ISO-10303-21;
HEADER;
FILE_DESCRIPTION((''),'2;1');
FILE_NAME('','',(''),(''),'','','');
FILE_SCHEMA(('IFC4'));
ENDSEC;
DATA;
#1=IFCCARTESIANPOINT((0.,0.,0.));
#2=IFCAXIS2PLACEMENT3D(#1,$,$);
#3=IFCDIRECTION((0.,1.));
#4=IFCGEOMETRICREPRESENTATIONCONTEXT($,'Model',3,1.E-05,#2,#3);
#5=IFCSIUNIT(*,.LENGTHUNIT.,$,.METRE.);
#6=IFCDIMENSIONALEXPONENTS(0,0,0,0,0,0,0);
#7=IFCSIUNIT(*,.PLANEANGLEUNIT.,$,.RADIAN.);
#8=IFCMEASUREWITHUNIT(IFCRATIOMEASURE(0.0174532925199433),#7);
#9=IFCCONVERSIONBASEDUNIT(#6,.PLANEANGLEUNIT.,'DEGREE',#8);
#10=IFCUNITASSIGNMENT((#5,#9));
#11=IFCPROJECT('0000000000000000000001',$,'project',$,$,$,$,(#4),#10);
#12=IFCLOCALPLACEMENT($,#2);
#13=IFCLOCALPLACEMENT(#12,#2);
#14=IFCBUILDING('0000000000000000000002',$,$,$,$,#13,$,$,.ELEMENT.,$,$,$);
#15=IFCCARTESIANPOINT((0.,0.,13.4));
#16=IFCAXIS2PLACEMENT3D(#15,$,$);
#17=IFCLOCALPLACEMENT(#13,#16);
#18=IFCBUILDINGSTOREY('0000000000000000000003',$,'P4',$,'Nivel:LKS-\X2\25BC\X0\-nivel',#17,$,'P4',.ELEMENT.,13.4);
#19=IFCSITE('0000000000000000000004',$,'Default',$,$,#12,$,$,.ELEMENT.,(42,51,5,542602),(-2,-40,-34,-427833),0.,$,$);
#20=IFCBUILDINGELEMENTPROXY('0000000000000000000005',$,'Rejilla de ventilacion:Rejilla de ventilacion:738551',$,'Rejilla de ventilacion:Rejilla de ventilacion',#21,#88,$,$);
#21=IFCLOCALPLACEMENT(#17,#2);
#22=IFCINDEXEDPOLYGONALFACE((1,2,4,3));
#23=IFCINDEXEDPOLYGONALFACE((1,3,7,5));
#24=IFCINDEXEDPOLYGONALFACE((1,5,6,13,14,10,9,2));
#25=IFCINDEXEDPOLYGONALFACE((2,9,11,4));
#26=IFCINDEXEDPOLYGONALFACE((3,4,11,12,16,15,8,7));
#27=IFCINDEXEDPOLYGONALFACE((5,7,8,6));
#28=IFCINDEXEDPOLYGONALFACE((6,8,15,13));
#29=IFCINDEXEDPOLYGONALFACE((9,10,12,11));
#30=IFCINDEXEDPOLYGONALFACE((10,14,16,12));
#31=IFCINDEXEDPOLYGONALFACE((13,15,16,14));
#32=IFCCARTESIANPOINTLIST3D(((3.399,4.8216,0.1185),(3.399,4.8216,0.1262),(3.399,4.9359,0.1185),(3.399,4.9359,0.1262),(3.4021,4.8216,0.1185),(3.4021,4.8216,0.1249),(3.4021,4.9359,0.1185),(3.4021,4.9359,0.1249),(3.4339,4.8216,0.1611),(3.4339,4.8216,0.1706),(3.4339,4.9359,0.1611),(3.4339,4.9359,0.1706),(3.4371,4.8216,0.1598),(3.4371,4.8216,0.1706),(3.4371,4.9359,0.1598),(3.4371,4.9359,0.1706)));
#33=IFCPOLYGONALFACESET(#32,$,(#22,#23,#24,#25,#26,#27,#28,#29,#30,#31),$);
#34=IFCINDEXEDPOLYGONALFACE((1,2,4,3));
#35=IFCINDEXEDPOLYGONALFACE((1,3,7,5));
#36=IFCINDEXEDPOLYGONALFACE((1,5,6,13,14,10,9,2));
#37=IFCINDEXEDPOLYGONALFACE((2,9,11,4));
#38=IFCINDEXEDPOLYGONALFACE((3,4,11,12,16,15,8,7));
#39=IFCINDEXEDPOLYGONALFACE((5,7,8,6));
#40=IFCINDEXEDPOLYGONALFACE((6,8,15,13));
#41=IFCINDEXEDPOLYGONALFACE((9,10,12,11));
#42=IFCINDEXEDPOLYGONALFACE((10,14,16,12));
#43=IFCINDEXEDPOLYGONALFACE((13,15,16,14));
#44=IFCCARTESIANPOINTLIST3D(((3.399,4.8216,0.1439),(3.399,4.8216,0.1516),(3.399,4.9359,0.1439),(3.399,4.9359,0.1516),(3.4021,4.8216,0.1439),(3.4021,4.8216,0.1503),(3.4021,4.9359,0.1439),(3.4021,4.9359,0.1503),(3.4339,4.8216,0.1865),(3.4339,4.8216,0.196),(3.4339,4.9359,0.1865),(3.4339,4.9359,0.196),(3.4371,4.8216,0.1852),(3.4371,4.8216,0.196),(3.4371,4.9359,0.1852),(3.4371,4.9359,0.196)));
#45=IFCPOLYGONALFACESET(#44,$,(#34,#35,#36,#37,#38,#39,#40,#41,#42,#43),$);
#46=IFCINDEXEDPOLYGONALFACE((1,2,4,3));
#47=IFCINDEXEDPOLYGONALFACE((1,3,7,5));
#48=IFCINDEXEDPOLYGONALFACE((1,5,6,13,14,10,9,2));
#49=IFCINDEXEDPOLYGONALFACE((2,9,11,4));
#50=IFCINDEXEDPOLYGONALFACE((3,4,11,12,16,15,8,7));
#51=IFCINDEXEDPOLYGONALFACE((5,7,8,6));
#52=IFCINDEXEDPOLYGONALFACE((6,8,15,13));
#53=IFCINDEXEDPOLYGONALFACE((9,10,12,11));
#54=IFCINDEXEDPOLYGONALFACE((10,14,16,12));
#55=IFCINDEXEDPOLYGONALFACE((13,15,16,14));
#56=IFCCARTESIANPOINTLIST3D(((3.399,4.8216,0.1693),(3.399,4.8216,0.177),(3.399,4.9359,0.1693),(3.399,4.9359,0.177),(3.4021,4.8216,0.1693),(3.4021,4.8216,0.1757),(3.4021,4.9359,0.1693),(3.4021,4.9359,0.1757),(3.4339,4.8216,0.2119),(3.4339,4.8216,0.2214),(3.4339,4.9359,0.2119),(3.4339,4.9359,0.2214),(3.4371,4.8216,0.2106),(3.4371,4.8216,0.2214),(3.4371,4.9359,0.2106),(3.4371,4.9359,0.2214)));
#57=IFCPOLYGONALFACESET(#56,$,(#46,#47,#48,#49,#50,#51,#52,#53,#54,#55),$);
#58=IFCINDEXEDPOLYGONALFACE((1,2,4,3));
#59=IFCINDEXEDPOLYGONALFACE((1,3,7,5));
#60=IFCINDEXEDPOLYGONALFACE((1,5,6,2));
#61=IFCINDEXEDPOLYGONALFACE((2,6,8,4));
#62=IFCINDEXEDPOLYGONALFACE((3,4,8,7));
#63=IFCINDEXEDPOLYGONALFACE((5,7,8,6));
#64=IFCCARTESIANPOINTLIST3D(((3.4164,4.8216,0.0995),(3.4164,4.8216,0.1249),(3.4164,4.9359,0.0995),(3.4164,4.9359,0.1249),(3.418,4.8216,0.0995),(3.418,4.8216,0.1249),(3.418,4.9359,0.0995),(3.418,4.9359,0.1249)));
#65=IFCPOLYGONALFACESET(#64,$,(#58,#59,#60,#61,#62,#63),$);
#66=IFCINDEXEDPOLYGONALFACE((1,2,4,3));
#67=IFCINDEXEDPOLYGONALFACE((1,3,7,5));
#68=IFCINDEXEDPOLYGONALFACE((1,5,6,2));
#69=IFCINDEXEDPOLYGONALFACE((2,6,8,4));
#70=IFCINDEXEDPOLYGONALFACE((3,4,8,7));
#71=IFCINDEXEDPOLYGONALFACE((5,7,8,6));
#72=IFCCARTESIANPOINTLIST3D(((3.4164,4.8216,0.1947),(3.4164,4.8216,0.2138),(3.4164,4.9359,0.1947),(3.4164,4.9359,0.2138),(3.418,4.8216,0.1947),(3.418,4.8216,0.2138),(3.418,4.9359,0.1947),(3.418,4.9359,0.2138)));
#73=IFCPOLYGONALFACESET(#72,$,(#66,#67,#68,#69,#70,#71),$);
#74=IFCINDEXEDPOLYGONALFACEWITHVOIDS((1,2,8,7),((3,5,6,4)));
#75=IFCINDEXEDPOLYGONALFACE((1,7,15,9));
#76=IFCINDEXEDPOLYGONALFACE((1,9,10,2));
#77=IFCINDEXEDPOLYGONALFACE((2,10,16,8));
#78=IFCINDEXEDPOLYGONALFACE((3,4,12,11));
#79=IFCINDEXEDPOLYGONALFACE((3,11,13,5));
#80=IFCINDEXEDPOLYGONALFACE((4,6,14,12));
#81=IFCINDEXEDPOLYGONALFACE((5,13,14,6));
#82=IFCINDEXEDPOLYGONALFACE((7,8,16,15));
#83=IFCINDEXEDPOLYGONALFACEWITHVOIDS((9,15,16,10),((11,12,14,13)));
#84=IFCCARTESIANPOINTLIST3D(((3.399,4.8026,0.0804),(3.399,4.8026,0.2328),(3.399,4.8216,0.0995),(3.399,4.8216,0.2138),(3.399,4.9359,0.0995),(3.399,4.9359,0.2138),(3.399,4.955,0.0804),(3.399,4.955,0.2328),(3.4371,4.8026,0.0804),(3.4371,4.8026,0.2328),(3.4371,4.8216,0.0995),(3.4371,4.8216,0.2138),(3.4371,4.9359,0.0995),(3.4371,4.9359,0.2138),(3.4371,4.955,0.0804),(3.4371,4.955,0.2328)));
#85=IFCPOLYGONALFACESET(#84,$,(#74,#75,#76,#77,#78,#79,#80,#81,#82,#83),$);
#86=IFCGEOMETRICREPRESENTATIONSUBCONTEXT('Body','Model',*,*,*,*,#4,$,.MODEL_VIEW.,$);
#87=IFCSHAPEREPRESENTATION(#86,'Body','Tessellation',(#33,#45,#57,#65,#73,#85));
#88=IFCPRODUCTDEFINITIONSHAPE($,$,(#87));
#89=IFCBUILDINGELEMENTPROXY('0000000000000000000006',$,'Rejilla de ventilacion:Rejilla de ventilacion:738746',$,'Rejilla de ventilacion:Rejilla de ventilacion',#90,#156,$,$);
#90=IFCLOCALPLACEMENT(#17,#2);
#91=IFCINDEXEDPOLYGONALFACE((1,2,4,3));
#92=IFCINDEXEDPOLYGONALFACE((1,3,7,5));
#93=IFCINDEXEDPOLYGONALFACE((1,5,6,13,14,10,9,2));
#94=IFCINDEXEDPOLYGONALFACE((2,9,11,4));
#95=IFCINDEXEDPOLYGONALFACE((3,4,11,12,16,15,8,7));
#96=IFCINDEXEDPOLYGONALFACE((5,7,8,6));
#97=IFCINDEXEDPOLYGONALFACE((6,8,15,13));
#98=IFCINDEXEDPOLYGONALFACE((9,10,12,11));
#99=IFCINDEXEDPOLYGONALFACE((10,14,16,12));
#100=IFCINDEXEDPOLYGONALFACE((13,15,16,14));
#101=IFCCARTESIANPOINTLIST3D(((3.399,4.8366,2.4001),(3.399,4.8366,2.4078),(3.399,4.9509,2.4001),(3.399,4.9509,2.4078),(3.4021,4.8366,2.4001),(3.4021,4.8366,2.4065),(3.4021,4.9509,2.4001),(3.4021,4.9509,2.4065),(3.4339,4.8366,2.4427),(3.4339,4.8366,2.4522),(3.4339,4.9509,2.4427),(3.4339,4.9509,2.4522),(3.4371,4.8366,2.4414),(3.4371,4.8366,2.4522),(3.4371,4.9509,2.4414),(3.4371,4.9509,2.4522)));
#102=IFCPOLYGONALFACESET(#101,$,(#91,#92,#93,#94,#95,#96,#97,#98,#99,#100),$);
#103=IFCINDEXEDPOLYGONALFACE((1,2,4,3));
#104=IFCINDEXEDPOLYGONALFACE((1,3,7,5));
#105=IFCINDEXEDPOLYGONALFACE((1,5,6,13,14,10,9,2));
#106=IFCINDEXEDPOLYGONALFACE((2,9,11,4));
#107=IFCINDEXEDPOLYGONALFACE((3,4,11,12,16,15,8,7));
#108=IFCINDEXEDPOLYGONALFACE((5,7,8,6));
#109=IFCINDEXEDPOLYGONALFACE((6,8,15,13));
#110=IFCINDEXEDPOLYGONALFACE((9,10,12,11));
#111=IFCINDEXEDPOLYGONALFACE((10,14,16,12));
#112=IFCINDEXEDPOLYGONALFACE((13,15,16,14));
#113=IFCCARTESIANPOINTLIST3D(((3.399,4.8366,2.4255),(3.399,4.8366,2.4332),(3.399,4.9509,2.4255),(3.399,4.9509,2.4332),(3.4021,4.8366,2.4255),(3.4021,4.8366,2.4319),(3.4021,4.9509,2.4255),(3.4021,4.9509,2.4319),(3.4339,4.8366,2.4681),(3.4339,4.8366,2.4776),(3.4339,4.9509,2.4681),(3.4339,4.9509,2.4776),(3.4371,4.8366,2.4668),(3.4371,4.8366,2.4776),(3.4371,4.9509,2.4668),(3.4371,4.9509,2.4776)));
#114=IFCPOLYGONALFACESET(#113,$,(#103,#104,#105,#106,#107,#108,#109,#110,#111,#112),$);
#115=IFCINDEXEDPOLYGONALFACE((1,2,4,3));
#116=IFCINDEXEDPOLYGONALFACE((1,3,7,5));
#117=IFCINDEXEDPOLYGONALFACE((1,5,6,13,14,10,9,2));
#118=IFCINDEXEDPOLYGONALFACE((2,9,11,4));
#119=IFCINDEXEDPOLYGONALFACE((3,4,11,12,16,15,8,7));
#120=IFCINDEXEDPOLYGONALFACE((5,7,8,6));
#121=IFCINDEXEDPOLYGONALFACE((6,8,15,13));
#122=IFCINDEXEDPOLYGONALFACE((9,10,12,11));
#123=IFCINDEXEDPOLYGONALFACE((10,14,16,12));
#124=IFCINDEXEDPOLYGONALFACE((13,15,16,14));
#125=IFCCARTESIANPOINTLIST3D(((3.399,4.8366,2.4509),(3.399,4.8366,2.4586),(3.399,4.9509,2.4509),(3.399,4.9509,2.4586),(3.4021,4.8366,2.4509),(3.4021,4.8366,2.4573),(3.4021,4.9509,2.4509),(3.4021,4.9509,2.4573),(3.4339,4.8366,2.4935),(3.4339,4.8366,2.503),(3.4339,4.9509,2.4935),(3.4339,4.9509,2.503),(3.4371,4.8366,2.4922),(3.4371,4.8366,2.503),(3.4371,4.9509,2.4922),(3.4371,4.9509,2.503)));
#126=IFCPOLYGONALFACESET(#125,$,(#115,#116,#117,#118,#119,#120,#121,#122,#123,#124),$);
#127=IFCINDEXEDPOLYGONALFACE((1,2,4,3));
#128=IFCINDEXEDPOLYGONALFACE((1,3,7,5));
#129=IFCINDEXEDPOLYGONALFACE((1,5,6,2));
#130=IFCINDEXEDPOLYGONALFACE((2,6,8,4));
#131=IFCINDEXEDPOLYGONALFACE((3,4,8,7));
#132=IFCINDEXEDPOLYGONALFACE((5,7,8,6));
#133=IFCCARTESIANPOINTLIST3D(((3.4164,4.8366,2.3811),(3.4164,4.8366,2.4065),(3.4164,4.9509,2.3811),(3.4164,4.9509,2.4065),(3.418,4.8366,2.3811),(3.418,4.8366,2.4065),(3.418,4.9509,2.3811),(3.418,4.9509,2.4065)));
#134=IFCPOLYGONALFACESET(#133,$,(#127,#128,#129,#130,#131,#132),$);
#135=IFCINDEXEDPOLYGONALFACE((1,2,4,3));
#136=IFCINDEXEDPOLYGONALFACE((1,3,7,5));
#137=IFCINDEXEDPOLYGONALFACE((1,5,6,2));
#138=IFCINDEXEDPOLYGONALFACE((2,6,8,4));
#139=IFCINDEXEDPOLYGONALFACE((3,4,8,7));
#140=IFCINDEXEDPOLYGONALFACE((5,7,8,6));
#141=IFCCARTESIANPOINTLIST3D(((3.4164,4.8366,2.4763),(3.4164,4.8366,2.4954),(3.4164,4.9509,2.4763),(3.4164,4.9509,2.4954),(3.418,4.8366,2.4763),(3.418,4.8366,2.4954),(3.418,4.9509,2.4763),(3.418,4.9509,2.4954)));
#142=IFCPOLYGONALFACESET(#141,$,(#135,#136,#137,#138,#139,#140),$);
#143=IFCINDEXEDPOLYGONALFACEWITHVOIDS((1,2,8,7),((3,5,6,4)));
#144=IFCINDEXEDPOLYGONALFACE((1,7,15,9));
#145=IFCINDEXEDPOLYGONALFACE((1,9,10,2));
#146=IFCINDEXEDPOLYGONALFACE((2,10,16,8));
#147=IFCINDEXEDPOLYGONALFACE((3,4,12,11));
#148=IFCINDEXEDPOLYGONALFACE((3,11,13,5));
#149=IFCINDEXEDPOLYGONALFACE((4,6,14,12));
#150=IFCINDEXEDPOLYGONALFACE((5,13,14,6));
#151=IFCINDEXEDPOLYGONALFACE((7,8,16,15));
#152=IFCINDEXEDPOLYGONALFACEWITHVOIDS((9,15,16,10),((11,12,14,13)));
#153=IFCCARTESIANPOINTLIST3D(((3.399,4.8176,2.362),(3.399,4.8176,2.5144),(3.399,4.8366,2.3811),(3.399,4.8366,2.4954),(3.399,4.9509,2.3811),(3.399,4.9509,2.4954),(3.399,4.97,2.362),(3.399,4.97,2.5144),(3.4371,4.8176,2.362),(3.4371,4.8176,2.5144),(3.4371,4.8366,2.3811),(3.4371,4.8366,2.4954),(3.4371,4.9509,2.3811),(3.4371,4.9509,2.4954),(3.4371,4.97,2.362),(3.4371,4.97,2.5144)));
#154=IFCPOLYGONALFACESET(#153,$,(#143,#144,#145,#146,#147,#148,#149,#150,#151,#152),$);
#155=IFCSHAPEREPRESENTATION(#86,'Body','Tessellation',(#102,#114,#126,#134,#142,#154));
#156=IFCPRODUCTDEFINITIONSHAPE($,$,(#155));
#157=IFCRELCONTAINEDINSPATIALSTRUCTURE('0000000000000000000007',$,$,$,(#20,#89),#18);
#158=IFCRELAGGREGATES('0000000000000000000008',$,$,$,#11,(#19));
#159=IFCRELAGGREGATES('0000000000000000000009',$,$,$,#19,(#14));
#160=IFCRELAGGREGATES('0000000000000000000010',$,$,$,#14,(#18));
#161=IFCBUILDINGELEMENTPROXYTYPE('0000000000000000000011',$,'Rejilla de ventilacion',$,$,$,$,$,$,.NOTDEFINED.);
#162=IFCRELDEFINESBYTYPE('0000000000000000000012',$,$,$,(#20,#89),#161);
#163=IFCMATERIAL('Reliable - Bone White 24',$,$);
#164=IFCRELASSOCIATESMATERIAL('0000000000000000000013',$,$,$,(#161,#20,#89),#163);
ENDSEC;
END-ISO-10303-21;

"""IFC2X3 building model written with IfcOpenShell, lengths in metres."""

from ifc_helpers import new_model, entity, si_unit, converted_unit, direction, frame, frame_2d, origin, place, context, subcontext, project, spatial, polyline, rectangle, outline, extrude, source, transform, mapped, material, type_object, type_shapes, element, save


model = new_model("IFC2X3")

# Units and contexts
model_context = context("Model", 3, precision=1e-05, world=origin(), true_north=direction((0.0, 1.0)))
body_context = subcontext(model_context, "Body", "Model", "MODEL_VIEW")
ifc_project = project(units=[si_unit("LENGTHUNIT", "METRE"), converted_unit("PLANEANGLEUNIT", "DEGREE", entity("IfcRatioMeasure", 0.0174532925199433), si_unit("PLANEANGLEUNIT", "RADIAN"), dimensions=[0, 0, 0, 0, 0, 0, 0])], contexts=[model_context])

# Site, building, storey
site_placement = place(None, origin())
site = spatial("IfcSite", under=ifc_project, at=site_placement, Name="Default", CompositionType="ELEMENT", RefLatitude=(42, 51, 5, 542602), RefLongitude=(-2, -40, -34, -427833), RefElevation=0.0)
building_placement = place(site_placement, origin())
building = spatial("IfcBuilding", under=site, at=building_placement, CompositionType="ELEMENT")
storey_placement = place(building_placement, frame((0.0, 0.0, 13.4)))
storey = spatial("IfcBuildingStorey", under=building, at=storey_placement, Name="P4", ObjectType="Nivel:LKS-▼-nivel", LongName="P4", CompositionType="ELEMENT", Elevation=13.4)

# Building element proxies
ifc_material_1 = material(Name="Reliable - Bone White 24")
building_element_proxy_type = type_object("IfcBuildingElementProxyType", Name="Rejilla de ventilacion", PredefinedType="NOTDEFINED", material=ifc_material_1)
shared_shape = source(origin(), body_context, "Body", "SweptSolid", [
    extrude(outline(polyline([(0.0173, 0.0159), (0.0269, 0.0159), (0.0269, 0.0191), (0.016, 0.0191), (-0.0189, -0.0159), (-0.0253, -0.0159), (-0.0253, -0.019), (-0.0176, -0.019), (0.0173, 0.0159)])), frame((-0.0571, 0.1, 1.435), z_axis=(1.0, 0.0, 0.0), x_axis=(0.0, 0.0, 1.0)), (0.0, 0.0, 1.0), 0.1143),
    extrude(outline(polyline([(0.0173, 0.0159), (0.0269, 0.0159), (0.0269, 0.0191), (0.016, 0.0191), (-0.0189, -0.0159), (-0.0253, -0.0159), (-0.0253, -0.019), (-0.0176, -0.019), (0.0173, 0.0159)])), frame((-0.0571, 0.1, 1.4604), z_axis=(1.0, 0.0, 0.0), x_axis=(0.0, 0.0, 1.0)), (0.0, 0.0, 1.0), 0.1143),
    extrude(outline(polyline([(0.0173, 0.0159), (0.0269, 0.0159), (0.0269, 0.0191), (0.016, 0.0191), (-0.0189, -0.0159), (-0.0253, -0.0159), (-0.0253, -0.019), (-0.0176, -0.019), (0.0173, 0.0159)])), frame((-0.0571, 0.1, 1.4858), z_axis=(1.0, 0.0, 0.0), x_axis=(0.0, 0.0, 1.0)), (0.0, 0.0, 1.0), 0.1143),
    extrude(rectangle(XDim=0.1143, YDim=0.0016, at=frame_2d((0.0, 0.0), x_axis=(1.0, 0.0))), frame((0.0, 0.1007, 1.3906), z_axis=(0.0, 0.0, 1.0), x_axis=(-1.0, 0.0, 0.0)), (0.0, 0.0, 1.0), 0.0254),
    extrude(rectangle(XDim=0.1143, YDim=0.0016, at=frame_2d((0.0, 0.0), x_axis=(1.0, 0.0))), frame((0.0, 0.1007, 1.4859), z_axis=(0.0, 0.0, 1.0), x_axis=(-1.0, 0.0, 0.0)), (0.0, 0.0, 1.0), 0.0191),
    extrude(outline(polyline([(-0.0762, -0.0762), (0.0762, -0.0762), (0.0762, 0.0762), (-0.0762, 0.0762), (-0.0762, -0.0762)]), holes=[polyline([(-0.0572, -0.0572), (-0.0572, 0.0572), (0.0572, 0.0572), (0.0572, -0.0572), (-0.0572, -0.0572)])]), frame((0.0, 0.0809, 1.4478), z_axis=(0.0, 1.0, 0.0), x_axis=(0.0, 0.0, 1.0)), (0.0, 0.0, 1.0), 0.0381),
])
type_shapes(building_element_proxy_type, [shared_shape])
for number, where, z_axis, x_axis, name in (
    (1, (3.518, 4.8788, -1.2912), (0.0, 0.0, 1.0), (0.0, 1.0, 0.0), "Rejilla de ventilacion:Rejilla de ventilacion:738551"),
    (2, (3.518, 4.8938, 0.9904), (0.0, 0.0, 1.0), (0.0, 1.0, 0.0), "Rejilla de ventilacion:Rejilla de ventilacion:738746"),
):
    element("IfcBuildingElementProxy", number, at=place(storey_placement, frame(where, z_axis=z_axis, x_axis=x_axis)), inside=storey, type_object=building_element_proxy_type, material=ifc_material_1, Name=name, ObjectType="Rejilla de ventilacion:Rejilla de ventilacion", context=body_context, shape_type="MappedRepresentation", body=[
        mapped(shared_shape, transform((0.0, 0.0, 0.0), scale=1.0)),
    ])

save(model, "model.ifc")
